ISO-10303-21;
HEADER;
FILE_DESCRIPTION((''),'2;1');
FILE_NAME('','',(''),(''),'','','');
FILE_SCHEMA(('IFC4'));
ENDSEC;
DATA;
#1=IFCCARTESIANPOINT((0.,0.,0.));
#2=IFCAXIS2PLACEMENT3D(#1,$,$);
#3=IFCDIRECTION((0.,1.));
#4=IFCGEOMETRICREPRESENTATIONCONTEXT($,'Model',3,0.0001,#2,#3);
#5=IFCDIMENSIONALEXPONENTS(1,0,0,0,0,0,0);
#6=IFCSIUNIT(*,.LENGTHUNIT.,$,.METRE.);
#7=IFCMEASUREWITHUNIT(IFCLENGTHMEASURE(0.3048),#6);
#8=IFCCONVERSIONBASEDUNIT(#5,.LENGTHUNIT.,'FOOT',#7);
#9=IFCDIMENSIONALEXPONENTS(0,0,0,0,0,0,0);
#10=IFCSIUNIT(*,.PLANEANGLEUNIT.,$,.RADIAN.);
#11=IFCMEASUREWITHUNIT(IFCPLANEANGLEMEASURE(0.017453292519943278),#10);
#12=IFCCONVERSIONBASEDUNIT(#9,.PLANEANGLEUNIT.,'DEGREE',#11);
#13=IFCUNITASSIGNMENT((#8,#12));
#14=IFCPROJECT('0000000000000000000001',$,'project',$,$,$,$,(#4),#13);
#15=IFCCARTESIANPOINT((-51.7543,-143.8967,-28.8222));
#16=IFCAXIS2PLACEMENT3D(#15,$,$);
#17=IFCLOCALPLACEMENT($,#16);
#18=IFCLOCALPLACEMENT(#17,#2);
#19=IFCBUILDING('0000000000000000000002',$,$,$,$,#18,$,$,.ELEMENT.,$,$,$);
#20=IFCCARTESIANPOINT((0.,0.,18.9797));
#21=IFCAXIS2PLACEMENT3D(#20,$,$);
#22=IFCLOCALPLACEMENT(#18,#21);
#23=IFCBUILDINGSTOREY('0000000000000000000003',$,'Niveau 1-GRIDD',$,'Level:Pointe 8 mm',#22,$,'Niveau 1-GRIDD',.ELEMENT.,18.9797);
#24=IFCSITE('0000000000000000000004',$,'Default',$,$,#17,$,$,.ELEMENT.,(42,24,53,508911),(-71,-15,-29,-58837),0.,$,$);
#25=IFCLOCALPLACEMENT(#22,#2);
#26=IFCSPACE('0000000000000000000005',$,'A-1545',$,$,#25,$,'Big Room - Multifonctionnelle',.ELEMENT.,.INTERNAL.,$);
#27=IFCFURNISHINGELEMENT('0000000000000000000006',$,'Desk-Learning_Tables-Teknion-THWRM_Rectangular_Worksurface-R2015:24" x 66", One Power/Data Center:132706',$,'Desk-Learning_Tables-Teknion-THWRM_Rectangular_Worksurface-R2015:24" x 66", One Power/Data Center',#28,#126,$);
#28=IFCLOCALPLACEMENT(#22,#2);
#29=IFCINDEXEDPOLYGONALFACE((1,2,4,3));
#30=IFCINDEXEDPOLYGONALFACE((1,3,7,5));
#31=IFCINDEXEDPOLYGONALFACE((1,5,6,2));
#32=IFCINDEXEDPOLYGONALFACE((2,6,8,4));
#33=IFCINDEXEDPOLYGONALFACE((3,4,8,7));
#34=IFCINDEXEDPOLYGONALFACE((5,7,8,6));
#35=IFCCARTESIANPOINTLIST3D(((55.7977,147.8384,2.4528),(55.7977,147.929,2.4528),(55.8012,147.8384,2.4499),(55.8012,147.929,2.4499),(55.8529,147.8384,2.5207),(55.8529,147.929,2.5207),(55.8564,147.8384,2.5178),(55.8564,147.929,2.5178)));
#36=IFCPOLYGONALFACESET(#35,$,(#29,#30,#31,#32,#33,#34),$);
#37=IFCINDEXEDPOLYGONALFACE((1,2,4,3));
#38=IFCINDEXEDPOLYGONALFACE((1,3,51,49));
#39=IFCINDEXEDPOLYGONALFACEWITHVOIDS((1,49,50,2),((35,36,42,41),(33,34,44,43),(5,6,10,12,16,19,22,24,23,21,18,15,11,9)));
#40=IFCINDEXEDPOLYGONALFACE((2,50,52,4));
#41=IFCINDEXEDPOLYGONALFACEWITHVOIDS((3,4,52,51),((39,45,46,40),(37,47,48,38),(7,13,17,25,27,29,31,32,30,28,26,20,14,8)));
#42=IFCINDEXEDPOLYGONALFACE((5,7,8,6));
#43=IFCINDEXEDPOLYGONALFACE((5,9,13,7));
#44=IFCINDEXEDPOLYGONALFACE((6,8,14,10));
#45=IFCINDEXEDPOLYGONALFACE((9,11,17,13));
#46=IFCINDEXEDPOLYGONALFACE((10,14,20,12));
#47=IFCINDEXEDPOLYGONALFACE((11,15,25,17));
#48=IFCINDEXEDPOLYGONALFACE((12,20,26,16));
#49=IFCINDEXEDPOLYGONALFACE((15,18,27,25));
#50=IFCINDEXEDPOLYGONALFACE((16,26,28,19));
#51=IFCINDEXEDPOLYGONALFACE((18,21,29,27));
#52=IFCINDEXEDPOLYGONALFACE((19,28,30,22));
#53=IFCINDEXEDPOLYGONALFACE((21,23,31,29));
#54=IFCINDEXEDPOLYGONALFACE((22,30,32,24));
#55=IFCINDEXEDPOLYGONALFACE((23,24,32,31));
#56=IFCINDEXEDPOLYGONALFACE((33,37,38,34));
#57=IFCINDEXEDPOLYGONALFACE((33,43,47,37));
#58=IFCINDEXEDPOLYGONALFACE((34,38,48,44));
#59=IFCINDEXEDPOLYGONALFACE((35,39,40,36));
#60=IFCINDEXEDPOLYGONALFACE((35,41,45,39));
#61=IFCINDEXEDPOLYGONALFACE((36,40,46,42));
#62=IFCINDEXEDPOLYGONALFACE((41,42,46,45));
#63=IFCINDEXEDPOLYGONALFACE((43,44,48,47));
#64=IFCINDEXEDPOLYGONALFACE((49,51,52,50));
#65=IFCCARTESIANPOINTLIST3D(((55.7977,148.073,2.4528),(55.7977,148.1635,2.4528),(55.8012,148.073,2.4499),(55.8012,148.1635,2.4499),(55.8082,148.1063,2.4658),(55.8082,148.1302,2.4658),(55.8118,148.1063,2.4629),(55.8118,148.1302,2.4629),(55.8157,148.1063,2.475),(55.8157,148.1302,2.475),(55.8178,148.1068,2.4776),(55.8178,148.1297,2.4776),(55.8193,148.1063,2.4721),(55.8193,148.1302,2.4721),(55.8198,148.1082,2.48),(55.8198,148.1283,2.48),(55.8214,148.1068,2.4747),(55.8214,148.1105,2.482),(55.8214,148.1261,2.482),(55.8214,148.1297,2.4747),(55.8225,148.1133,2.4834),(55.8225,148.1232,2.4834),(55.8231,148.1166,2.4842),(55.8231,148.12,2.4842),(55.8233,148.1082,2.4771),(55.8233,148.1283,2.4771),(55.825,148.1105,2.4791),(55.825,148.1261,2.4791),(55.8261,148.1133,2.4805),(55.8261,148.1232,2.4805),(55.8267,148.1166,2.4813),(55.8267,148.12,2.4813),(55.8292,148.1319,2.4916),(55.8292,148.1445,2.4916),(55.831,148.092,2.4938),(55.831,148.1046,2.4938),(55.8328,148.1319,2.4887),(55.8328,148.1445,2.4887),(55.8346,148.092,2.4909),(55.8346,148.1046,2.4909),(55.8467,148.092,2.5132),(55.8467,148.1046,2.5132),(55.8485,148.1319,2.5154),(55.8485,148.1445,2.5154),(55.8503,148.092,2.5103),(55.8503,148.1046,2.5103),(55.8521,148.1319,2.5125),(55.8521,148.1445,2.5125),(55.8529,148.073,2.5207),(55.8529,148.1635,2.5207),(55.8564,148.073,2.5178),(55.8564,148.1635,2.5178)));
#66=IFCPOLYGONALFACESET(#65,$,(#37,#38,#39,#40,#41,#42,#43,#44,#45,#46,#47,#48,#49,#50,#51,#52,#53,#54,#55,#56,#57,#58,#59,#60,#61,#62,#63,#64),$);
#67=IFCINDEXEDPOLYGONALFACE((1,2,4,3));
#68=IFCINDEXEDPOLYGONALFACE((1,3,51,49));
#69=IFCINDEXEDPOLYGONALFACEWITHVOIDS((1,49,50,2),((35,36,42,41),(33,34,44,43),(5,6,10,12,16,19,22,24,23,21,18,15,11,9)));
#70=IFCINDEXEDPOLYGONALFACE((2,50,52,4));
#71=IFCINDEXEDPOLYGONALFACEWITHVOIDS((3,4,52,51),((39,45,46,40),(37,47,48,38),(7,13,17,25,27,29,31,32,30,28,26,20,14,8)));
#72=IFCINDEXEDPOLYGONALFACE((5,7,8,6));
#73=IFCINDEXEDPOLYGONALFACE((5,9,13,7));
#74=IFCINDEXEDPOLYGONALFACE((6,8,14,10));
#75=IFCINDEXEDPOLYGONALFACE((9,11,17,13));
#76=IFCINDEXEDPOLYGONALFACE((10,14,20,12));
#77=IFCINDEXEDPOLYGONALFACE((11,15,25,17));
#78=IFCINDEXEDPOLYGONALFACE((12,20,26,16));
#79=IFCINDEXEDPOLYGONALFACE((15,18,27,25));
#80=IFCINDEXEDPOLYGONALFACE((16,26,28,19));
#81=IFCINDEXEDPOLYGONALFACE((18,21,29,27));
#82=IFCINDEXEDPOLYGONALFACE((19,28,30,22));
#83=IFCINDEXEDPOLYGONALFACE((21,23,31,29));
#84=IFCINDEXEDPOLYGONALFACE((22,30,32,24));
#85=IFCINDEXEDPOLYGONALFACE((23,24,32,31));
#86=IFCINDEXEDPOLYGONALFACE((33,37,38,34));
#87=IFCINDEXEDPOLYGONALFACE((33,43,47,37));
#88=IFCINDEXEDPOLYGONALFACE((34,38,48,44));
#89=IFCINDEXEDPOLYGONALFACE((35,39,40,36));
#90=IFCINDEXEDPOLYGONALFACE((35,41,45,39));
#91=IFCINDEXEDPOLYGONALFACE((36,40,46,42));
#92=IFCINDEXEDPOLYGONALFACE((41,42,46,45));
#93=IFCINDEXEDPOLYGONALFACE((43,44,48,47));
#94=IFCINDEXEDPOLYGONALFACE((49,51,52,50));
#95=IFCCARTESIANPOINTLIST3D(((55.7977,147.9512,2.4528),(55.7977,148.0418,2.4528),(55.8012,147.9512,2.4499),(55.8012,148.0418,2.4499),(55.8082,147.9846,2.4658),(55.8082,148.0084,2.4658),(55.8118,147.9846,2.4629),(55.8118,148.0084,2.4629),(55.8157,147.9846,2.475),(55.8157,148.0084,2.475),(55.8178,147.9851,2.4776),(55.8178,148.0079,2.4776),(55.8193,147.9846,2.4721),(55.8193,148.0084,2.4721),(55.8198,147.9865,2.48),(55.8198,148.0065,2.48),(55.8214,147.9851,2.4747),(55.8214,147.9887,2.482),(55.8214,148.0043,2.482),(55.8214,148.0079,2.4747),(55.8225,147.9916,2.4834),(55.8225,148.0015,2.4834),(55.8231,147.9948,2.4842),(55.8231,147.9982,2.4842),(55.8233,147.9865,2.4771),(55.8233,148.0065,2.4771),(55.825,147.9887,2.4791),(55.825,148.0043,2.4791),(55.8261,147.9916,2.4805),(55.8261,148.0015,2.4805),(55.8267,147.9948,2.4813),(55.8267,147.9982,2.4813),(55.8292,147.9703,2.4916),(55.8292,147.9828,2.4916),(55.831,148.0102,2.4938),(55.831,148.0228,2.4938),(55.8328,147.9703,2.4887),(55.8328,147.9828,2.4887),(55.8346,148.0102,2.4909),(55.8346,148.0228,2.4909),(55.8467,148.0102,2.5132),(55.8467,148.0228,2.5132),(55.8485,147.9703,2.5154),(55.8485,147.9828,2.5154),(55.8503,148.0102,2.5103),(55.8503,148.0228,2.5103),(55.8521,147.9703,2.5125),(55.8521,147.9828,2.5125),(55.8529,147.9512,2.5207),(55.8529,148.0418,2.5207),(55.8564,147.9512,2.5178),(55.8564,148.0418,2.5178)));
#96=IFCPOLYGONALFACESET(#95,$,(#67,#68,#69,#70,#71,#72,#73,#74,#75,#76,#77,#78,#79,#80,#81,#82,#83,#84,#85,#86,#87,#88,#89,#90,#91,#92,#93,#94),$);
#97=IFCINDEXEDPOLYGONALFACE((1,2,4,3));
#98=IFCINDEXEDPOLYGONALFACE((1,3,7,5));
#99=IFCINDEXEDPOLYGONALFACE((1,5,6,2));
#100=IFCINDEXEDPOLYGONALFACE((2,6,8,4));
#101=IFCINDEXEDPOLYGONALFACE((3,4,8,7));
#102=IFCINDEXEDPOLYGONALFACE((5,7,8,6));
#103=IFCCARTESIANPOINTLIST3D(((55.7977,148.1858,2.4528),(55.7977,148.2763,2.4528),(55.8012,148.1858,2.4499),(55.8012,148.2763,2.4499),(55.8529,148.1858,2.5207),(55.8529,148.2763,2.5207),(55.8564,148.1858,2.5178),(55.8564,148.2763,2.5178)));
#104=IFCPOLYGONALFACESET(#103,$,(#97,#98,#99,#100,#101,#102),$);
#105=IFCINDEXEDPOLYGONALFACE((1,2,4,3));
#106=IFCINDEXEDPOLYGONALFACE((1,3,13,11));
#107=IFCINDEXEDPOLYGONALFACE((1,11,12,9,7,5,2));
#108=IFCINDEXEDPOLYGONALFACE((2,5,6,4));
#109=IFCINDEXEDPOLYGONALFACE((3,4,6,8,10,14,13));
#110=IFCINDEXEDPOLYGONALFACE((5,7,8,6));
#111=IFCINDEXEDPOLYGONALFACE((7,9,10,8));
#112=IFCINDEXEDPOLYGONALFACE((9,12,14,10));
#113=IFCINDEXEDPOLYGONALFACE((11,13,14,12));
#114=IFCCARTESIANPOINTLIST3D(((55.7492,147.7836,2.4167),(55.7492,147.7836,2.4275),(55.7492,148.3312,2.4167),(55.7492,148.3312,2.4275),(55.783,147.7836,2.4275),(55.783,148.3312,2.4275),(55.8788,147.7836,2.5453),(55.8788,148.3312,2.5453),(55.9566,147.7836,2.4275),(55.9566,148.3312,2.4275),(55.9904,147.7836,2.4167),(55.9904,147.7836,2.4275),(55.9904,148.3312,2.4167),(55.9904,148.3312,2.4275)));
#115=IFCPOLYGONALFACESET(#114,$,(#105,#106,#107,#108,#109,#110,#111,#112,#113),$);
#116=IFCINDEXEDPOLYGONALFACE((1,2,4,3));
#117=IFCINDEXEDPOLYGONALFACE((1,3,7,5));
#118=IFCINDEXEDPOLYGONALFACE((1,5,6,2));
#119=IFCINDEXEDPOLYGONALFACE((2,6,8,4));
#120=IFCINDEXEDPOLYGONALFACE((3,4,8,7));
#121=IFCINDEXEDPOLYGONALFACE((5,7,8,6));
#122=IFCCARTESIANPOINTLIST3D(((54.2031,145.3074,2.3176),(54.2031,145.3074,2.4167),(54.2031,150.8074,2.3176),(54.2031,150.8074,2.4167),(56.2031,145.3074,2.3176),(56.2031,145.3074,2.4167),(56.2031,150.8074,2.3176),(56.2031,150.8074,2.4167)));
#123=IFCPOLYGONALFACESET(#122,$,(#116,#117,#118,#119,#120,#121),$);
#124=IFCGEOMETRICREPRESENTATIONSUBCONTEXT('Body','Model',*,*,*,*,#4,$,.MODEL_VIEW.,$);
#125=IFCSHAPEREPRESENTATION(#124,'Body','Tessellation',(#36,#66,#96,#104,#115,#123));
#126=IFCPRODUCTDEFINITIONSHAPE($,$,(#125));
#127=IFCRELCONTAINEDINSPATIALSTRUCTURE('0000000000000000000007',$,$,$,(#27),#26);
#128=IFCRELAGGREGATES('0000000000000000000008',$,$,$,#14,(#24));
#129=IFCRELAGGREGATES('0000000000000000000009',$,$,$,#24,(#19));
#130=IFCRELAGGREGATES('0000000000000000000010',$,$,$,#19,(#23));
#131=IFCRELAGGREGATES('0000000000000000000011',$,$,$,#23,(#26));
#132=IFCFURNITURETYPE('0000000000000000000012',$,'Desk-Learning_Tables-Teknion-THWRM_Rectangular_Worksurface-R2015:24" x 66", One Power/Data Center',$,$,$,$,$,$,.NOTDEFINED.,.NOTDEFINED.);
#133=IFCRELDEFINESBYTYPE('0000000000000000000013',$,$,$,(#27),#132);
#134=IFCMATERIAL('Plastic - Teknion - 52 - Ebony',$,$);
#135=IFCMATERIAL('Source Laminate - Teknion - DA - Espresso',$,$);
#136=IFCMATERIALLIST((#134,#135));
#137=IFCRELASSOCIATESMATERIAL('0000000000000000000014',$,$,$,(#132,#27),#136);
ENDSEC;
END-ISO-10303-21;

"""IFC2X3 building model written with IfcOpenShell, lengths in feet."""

from ifc_helpers import new_model, entity, si_unit, converted_unit, direction, frame, frame_2d, origin, place, context, subcontext, project, spatial, polyline, circle_curve, parameter, trimmed, segment, composite_curve, rectangle, outline, extrude, source, transform, mapped, material, material_list, type_object, type_shapes, element, save


model = new_model("IFC2X3")

# Units and contexts
model_context = context("Model", 3, precision=0.0001, world=origin(), true_north=direction((0.0, 1.0)))
body_context = subcontext(model_context, "Body", "Model", "MODEL_VIEW")
ifc_project = project(units=[converted_unit("LENGTHUNIT", "FOOT", entity("IfcLengthMeasure", 0.3048), si_unit("LENGTHUNIT", "METRE"), dimensions=[1, 0, 0, 0, 0, 0, 0]), converted_unit("PLANEANGLEUNIT", "DEGREE", entity("IfcPlaneAngleMeasure", 0.017453292519943278), si_unit("PLANEANGLEUNIT", "RADIAN"), dimensions=[0, 0, 0, 0, 0, 0, 0])], contexts=[model_context])

# Site, building, storey
site_placement = place(None, frame((-51.7543, -143.8967, -28.8222)))
site = spatial("IfcSite", under=ifc_project, at=site_placement, Name="Default", CompositionType="ELEMENT", RefLatitude=(42, 24, 53, 508911), RefLongitude=(-71, -15, -29, -58837), RefElevation=0.0)
building_placement = place(site_placement, origin())
building = spatial("IfcBuilding", under=site, at=building_placement, CompositionType="ELEMENT")
storey_placement = place(building_placement, frame((0.0, 0.0, 18.9797)))
storey = spatial("IfcBuildingStorey", under=building, at=storey_placement, Name="Niveau 1-GRIDD", ObjectType="Level:Pointe 8 mm", LongName="Niveau 1-GRIDD", CompositionType="ELEMENT", Elevation=18.9797)

# Shared definitions
space_placement = place(storey_placement, origin())
space = spatial("IfcSpace", under=storey, at=space_placement, Name="A-1545", LongName="Big Room - Multifonctionnelle", CompositionType="ELEMENT", InteriorOrExteriorSpace="INTERNAL")

# Furnishing element
ifc_material_1 = material(Name="Plastic - Teknion - 52 - Ebony")
ifc_material_2 = material(Name="Source Laminate - Teknion - DA - Espresso")
ifc_material_list_1 = material_list([ifc_material_1, ifc_material_2])
furniture_type_1 = type_object("IfcFurnitureType", Name="Desk-Learning_Tables-Teknion-THWRM_Rectangular_Worksurface-R2015:24\" x 66\", One Power/Data Center", AssemblyPlace="NOTDEFINED", material=ifc_material_list_1)
shared_shape_1 = source(origin(), body_context, "Body", "SweptSolid", [
    extrude(rectangle(XDim=0.0875, YDim=0.0046, at=frame_2d((0.0, 0.0), x_axis=(0.0, 1.0))), frame((0.1284, 0.6239, 2.4853), z_axis=(1.0, 0.0, 0.0), x_axis=(0.0, 0.776046, -0.630676)), (0.0, 0.0, 1.0), 0.0906),
    extrude(outline(polyline([(-0.0453, -0.0438), (0.0453, -0.0438), (0.0453, 0.0438), (-0.0453, 0.0438), (-0.0453, -0.0438)]), holes=[polyline([(-0.0262, -0.0063), (-0.0137, -0.0063), (-0.0137, -0.0369), (-0.0262, -0.0369), (-0.0262, -0.0063)]), polyline([(0.0137, -0.0341), (0.0137, -0.0091), (0.0262, -0.0091), (0.0262, -0.0341), (0.0137, -0.0341)]), composite_curve([segment(polyline([(-0.0119, 0.027), (0.0119, 0.027)]), True, "CONTINUOUS"), segment(polyline([(0.0119, 0.027), (0.0119, 0.0151)]), True, "CONTINUOUS"), segment(trimmed(circle_curve(frame_2d((0.0, 0.0151), x_axis=(0.0, -1.0)), 0.0119), [parameter(270.0)], [parameter(90.0)], True, "PARAMETER"), False, "CONTINUOUS"), segment(polyline([(-0.0119, 0.0151), (-0.0119, 0.027)]), True, "CONTINUOUS")], self_intersect=False)]), frame((-0.0609, 0.6221, 2.4867), z_axis=(0.0, 0.776046, -0.630676), x_axis=(1.0, 0.0, 0.0)), (0.0, 0.0, 1.0), 0.0046),
    extrude(outline(polyline([(-0.0438, -0.0453), (0.0438, -0.0453), (0.0438, 0.0453), (-0.0438, 0.0453), (-0.0438, -0.0453)]), holes=[polyline([(-0.0063, -0.0262), (-0.0369, -0.0262), (-0.0369, -0.0137), (-0.0063, -0.0137), (-0.0063, -0.0262)]), polyline([(-0.0341, 0.0137), (-0.0341, 0.0262), (-0.0091, 0.0262), (-0.0091, 0.0137), (-0.0341, 0.0137)]), composite_curve([segment(polyline([(0.027, -0.0119), (0.0151, -0.0119)]), True, "CONTINUOUS"), segment(trimmed(circle_curve(frame_2d((0.0151, 0.0), x_axis=(-1.0, 0.0)), 0.0119), [parameter(270.0)], [parameter(90.0)], True, "PARAMETER"), False, "CONTINUOUS"), segment(polyline([(0.0151, 0.0119), (0.027, 0.0119)]), True, "CONTINUOUS"), segment(polyline([(0.027, 0.0119), (0.027, -0.0119)]), True, "CONTINUOUS")], self_intersect=False)]), frame((0.0609, 0.6221, 2.4867), z_axis=(0.0, 0.776046, -0.630676), x_axis=(0.0, -0.630676, -0.776046)), (0.0, 0.0, 1.0), 0.0046),
    extrude(rectangle(XDim=0.0875, YDim=0.0046, at=frame_2d((0.0, 0.0), x_axis=(0.0, 1.0))), frame((-0.219, 0.6239, 2.4853), z_axis=(1.0, 0.0, 0.0), x_axis=(0.0, 0.776046, -0.630676)), (0.0, 0.0, 1.0), 0.0906),
    extrude(outline(polyline([(-0.0586, -0.0638), (0.0826, -0.0638), (0.0371, 0.0811), (0.0557, 0.1093), (0.0467, 0.1152), (-0.0862, -0.086), (-0.0772, -0.092), (-0.0586, -0.0638)])), frame((-0.2738, 0.6679, 2.4412), z_axis=(1.0, 0.0, 0.0), x_axis=(0.0, -0.551103, 0.834437)), (0.0, 0.0, 1.0), 0.5475),
    extrude(rectangle(XDim=5.5, YDim=2.0, at=frame_2d((0.0, 0.0), x_axis=(1.0, 0.0))), frame((0.0, 0.0, 2.3176), z_axis=(0.0, 0.0, 1.0), x_axis=(-1.0, 0.0, 0.0)), (0.0, 0.0, 1.0), 0.0991),
])
type_shapes(furniture_type_1, [shared_shape_1])
for number, where, z_axis, x_axis, name in (
    (1, (55.2031, 148.0574, 0.0), (0.0, 0.0, 1.0), (0.0, -1.0, 0.0), "Desk-Learning_Tables-Teknion-THWRM_Rectangular_Worksurface-R2015:24\" x 66\", One Power/Data Center:132706"),
):
    element("IfcFurnishingElement", number, at=place(space_placement, frame(where, z_axis=z_axis, x_axis=x_axis)), inside=space, type_object=furniture_type_1, material=ifc_material_list_1, Name=name, ObjectType="Desk-Learning_Tables-Teknion-THWRM_Rectangular_Worksurface-R2015:24\" x 66\", One Power/Data Center", context=body_context, shape_type="MappedRepresentation", body=[
        mapped(shared_shape_1, transform((0.0, 0.0, 0.0), scale=1.0)),
    ])

save(model, "model.ifc")
